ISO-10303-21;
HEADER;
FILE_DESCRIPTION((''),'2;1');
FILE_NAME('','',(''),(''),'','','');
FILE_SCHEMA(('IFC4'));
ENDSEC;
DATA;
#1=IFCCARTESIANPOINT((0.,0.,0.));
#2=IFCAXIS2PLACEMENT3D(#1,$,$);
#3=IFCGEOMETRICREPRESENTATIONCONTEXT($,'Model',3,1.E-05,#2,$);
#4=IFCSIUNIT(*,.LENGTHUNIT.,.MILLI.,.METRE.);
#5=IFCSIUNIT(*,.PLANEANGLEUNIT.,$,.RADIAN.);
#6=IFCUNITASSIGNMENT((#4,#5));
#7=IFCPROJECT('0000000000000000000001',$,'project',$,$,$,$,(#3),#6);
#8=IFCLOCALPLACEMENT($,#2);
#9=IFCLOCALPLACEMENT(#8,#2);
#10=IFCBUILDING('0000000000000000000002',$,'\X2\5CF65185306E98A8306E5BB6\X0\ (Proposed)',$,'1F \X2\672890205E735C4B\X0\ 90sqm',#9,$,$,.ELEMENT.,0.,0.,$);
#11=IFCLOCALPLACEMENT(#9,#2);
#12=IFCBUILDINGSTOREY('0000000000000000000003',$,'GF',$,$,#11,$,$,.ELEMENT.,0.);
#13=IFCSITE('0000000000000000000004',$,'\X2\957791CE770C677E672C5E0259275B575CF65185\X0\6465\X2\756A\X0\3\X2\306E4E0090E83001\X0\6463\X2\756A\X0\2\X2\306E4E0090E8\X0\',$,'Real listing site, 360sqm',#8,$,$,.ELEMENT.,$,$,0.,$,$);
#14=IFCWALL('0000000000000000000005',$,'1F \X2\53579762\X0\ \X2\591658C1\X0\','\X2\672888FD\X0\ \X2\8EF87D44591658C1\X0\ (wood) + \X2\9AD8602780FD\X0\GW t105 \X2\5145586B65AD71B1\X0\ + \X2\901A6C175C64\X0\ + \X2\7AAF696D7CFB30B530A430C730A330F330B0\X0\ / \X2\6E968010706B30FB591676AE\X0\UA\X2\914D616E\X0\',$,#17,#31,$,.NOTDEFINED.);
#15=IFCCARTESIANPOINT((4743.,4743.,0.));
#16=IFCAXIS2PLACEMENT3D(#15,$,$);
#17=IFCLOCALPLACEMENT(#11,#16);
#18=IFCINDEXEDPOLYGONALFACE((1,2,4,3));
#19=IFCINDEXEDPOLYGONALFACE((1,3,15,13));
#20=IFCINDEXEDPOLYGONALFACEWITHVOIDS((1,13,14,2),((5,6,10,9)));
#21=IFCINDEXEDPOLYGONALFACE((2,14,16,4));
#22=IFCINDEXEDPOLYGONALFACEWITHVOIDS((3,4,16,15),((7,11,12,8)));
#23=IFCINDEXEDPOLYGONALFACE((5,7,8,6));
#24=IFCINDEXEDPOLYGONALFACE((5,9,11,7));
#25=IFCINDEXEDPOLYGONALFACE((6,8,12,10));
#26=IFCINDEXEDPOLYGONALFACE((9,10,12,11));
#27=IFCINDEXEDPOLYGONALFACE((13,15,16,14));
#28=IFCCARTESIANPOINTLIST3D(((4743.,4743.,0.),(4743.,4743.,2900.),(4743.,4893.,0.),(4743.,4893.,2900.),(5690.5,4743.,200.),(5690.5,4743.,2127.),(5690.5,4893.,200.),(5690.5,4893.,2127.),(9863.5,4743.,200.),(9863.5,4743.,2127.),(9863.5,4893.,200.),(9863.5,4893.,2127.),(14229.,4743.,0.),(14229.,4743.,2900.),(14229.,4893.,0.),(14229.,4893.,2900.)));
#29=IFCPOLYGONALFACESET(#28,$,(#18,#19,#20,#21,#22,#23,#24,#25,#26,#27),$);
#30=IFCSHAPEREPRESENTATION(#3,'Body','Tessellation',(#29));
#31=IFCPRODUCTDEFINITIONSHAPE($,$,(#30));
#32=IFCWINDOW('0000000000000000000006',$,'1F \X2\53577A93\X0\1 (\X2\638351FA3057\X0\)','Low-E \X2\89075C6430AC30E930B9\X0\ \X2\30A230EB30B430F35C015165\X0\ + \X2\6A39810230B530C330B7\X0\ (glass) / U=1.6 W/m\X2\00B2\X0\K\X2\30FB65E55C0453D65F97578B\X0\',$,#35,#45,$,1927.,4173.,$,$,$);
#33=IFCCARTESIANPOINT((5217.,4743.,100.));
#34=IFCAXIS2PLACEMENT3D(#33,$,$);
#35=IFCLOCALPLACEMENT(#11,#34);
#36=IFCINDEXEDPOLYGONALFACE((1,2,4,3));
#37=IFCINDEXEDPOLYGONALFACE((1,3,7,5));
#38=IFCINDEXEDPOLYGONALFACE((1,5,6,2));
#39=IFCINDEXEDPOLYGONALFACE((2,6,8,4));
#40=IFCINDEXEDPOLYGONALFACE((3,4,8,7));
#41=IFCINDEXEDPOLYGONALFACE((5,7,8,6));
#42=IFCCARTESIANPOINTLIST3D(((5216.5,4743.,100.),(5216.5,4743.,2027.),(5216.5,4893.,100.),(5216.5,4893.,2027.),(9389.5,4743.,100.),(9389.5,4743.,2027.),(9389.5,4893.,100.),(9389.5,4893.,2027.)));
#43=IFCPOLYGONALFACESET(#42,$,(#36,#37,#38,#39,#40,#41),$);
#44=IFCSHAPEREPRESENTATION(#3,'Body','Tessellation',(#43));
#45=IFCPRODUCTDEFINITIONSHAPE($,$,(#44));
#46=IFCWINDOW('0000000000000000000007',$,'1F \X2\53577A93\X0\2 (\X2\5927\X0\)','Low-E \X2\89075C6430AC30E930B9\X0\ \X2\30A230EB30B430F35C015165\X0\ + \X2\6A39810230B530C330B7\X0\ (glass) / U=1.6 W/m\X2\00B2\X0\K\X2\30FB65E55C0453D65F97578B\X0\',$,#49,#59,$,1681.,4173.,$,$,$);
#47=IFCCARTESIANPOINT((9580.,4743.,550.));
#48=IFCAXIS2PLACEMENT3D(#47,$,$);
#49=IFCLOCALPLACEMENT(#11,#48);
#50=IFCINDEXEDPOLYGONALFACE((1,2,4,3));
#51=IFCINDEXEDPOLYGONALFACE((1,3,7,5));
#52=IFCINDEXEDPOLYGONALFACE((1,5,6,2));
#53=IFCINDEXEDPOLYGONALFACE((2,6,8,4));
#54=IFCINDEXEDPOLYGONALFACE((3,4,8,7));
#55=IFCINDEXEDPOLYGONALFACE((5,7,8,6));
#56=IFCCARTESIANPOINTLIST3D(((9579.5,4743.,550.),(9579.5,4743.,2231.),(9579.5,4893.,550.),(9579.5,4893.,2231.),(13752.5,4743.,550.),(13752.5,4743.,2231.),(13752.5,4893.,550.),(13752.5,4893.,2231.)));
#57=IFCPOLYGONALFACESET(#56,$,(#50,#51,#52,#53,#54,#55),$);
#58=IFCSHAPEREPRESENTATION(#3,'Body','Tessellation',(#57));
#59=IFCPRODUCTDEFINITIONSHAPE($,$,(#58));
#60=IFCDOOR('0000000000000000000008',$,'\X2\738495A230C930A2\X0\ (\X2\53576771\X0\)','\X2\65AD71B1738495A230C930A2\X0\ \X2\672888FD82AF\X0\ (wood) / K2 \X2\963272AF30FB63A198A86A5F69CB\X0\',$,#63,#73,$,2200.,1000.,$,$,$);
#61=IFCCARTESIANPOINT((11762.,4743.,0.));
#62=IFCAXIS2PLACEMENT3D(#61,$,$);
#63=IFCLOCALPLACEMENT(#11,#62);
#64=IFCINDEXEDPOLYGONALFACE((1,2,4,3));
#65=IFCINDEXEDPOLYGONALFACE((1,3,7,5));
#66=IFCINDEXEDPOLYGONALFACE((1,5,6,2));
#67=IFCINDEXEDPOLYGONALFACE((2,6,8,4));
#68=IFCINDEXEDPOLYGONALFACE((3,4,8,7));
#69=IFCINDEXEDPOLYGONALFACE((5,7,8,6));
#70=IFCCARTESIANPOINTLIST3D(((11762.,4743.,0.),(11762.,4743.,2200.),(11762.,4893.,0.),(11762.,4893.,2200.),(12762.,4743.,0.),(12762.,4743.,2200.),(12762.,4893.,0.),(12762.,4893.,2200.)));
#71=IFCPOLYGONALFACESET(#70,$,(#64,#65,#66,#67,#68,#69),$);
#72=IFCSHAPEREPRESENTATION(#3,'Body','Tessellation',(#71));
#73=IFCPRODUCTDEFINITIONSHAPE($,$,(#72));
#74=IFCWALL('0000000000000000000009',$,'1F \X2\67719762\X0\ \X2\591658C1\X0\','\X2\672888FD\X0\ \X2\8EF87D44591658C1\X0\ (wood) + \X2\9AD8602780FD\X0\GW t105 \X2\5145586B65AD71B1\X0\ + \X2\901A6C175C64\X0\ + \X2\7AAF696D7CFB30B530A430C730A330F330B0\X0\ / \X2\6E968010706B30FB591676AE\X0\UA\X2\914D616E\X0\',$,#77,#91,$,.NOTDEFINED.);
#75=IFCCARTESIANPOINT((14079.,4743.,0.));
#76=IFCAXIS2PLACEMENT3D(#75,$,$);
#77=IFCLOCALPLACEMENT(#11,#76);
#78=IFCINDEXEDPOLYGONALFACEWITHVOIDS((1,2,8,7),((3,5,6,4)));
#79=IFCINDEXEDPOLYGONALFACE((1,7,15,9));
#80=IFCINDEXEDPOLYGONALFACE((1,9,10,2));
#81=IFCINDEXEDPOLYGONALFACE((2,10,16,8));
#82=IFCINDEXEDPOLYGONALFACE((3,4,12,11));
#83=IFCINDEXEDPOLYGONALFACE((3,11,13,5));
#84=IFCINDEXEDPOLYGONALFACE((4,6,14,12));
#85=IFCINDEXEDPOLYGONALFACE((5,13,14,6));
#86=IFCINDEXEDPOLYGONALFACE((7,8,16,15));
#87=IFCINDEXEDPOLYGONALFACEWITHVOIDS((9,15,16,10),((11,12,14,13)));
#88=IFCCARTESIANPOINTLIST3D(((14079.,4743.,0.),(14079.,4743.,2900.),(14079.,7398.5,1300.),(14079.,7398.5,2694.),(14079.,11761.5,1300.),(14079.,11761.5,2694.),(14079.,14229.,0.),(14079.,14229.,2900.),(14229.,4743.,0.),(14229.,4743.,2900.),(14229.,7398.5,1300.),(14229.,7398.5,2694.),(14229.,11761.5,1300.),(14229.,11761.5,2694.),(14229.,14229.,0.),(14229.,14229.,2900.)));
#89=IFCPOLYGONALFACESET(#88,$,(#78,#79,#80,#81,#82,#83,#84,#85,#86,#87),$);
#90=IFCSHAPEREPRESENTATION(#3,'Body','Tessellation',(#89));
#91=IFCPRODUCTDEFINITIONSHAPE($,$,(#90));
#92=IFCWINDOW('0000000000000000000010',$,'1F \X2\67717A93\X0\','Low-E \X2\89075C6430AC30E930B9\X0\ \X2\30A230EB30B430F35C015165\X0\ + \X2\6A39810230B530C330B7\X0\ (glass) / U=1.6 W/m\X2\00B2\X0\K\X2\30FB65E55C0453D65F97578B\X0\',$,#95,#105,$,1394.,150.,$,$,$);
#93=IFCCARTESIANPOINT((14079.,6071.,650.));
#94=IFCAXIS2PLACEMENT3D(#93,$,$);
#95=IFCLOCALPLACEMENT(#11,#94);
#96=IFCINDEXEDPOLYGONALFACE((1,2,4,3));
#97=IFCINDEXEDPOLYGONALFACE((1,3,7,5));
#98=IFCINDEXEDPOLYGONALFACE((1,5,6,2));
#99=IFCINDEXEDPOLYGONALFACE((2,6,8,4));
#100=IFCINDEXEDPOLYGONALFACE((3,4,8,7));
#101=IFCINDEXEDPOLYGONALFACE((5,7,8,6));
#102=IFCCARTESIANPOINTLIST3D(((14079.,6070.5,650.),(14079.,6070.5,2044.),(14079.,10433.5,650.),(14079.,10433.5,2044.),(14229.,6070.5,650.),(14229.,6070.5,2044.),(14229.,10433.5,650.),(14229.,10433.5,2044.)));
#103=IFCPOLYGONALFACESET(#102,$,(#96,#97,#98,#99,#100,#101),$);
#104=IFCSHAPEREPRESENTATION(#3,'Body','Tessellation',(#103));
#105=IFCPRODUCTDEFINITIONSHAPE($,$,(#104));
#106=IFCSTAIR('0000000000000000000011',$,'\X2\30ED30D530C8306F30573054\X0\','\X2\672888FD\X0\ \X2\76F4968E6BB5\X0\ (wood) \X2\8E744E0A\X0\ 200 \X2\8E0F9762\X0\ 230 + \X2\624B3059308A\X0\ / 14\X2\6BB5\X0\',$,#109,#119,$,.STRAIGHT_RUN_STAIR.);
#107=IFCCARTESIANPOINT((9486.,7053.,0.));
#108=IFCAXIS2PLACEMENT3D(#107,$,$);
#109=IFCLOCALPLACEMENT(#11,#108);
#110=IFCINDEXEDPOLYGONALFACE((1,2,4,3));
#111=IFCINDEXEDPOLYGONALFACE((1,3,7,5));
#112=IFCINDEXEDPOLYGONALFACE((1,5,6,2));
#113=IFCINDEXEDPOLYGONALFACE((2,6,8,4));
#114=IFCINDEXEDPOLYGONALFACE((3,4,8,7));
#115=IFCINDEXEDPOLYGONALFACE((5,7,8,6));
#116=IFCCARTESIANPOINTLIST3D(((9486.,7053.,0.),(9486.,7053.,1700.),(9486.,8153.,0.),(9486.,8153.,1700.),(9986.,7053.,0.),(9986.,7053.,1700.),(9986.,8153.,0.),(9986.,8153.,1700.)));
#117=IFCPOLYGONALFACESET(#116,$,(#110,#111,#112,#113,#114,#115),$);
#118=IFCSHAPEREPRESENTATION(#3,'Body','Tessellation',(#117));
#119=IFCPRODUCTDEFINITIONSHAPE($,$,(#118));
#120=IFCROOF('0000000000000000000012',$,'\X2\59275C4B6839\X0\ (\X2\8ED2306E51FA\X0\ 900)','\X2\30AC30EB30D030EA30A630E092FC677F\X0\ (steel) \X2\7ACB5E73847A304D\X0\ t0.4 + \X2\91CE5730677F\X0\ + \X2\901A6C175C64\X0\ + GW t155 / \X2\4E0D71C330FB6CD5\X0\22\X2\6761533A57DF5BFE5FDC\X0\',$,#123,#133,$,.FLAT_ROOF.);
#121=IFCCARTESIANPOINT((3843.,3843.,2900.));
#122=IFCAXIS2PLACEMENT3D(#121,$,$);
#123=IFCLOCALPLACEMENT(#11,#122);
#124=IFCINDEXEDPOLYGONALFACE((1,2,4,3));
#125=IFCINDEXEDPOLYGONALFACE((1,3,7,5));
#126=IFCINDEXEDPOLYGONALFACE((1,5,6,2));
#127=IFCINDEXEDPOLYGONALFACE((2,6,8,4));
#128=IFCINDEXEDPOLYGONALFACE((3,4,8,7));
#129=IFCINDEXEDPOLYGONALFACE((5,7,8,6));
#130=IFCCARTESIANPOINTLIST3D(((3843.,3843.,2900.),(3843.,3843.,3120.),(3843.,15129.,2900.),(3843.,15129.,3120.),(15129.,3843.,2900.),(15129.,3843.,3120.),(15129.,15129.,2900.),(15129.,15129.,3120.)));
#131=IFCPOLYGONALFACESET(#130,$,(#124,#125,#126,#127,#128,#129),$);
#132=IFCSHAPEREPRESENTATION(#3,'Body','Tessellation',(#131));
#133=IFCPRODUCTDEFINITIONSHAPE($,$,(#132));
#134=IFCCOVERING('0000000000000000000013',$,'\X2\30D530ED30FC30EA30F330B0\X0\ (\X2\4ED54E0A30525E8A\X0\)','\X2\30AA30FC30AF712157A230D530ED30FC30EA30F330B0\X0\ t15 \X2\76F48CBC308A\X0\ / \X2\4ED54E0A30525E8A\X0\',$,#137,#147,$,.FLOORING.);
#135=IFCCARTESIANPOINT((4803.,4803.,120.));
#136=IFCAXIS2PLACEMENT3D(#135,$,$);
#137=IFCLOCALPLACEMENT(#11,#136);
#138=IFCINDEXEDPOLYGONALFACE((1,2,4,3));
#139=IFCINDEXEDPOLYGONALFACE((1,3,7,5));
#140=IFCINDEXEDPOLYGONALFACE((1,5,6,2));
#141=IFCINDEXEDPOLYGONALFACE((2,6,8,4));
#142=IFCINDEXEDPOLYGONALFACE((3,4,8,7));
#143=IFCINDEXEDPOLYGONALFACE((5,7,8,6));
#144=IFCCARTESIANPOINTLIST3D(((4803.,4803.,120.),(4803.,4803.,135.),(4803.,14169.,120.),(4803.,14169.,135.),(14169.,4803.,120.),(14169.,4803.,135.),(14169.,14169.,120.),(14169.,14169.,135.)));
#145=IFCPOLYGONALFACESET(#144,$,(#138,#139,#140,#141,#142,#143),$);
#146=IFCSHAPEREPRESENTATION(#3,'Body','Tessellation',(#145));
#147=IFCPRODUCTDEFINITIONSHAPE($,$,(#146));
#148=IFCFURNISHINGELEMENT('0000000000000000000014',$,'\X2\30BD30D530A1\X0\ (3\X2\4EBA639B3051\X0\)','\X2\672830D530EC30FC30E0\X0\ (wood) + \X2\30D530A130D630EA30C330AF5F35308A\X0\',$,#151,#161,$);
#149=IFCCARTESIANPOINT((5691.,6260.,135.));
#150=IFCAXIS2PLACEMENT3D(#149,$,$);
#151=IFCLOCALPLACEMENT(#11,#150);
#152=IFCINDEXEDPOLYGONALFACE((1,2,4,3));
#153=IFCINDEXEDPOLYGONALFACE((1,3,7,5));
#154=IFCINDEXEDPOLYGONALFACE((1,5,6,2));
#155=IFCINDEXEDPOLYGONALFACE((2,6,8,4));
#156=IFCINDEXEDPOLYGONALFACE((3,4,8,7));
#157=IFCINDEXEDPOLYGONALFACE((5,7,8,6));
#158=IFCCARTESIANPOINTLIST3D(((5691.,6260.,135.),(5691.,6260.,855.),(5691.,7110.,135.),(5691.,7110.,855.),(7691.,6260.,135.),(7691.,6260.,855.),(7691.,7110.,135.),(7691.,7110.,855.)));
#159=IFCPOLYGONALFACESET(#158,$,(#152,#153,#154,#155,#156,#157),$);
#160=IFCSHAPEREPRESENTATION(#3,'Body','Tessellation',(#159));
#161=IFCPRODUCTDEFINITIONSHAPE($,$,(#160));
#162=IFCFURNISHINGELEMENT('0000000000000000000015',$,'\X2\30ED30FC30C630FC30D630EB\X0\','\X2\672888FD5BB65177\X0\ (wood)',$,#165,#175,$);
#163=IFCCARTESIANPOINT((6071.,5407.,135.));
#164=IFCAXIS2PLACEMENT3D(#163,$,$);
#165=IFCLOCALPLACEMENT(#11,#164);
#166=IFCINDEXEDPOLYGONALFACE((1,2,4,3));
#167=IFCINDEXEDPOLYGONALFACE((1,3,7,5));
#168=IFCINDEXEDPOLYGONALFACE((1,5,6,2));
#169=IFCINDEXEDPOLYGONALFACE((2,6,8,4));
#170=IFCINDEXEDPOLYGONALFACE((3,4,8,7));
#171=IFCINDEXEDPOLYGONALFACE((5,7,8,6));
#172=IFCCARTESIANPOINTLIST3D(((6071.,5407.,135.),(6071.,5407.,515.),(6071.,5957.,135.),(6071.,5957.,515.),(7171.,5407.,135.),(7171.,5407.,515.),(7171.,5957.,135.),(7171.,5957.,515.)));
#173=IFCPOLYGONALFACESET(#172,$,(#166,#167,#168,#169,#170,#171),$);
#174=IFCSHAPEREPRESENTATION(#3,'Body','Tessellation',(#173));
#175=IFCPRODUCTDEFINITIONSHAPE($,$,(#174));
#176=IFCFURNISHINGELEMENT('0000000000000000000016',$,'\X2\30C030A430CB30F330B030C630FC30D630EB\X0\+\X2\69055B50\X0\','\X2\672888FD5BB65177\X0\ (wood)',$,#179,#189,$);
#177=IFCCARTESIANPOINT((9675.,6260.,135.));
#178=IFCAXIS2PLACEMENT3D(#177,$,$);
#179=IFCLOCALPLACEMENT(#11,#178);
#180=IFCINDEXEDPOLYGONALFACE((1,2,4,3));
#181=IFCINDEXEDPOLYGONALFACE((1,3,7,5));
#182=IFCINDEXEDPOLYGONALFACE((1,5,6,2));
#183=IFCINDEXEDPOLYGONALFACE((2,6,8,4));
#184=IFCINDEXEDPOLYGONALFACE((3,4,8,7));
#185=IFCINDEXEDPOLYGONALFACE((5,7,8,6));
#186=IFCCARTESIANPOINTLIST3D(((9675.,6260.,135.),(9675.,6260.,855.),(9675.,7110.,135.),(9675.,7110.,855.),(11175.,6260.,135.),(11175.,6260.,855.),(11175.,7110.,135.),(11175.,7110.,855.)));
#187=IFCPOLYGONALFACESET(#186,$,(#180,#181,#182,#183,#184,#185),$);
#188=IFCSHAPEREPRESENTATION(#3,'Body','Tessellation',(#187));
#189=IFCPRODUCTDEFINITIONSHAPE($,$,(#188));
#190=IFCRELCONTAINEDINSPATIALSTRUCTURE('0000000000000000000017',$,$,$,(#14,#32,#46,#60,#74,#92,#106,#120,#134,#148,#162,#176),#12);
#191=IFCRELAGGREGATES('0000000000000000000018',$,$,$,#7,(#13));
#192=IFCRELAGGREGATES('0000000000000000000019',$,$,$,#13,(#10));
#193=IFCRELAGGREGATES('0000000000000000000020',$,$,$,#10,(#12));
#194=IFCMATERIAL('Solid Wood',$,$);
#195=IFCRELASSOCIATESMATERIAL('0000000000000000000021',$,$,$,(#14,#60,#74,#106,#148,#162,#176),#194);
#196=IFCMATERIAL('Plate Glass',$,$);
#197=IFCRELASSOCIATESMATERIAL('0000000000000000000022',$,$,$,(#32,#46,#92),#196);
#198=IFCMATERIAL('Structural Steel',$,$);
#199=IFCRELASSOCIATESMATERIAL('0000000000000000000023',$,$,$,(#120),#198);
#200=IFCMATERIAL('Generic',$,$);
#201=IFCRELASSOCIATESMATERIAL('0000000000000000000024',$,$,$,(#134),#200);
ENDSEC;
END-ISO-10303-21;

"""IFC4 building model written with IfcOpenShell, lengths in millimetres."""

from ifc_helpers import new_model, si_unit, frame, frame_2d, origin, place, context, project, spatial, rectangle, extrude, material, element, fill, save


model = new_model("IFC4")

# Units and contexts
model_context = context("Model", 3, precision=1e-05, world=origin())
ifc_project = project(units=[si_unit("LENGTHUNIT", "METRE", prefix="MILLI"), si_unit("PLANEANGLEUNIT", "RADIAN")], contexts=[model_context])

# Site, building, storey
site_placement = place(None, origin())
site = spatial("IfcSite", under=ifc_project, at=site_placement, Name="長野県松本市大字島内6465番3の一部、6463番2の一部", ObjectType="Real listing site, 360sqm", CompositionType="ELEMENT", RefElevation=0.0)
building_placement = place(site_placement, origin())
building = spatial("IfcBuilding", under=site, at=building_placement, Name="島内の風の家 (Proposed)", ObjectType="1F 木造平屋 90sqm", CompositionType="ELEMENT", ElevationOfRefHeight=0.0, ElevationOfTerrain=0.0)
storey_placement = place(building_placement, origin())
storey = spatial("IfcBuildingStorey", under=building, at=storey_placement, Name="GF", CompositionType="ELEMENT", Elevation=0.0)

# Shared definitions
ifc_material_1 = material(Name="Solid Wood")

# Wall, openings, windows, door
wall_1_placement = place(storey_placement, frame((4743.0, 4743.0, 0.0)))
wall_1 = element("IfcWall", 1, at=wall_1_placement, inside=storey, material=ifc_material_1, Name="1F 南面 外壁", Description="木製 軸組外壁 (wood) + 高性能GW t105 充填断熱 + 通気層 + 窯業系サイディング / 準耐火・外皮UA配慮", PredefinedType="NOTDEFINED", context=model_context, shape_type="SweptSolid", body=[
    extrude(rectangle(XDim=9486.0, YDim=150.0, at=frame_2d((4743.0, 75.0))), frame((4743.0, 4743.0, 0.0)), (0.0, 0.0, 1.0), 2900.0),
])
opening_1_placement = place(storey_placement, frame((5217.0, 4743.0, 100.0)))
opening_1 = element("IfcOpeningElement", 2, at=opening_1_placement, cuts=wall_1, PredefinedType="NOTDEFINED", context=model_context, shape_type="SweptSolid", body=[
    extrude(rectangle(XDim=4173.0, YDim=150.0, at=frame_2d((2086.0, 75.0))), frame((5217.0, 4743.0, 100.0)), (0.0, 0.0, 1.0), 1927.0),
])
opening_2_placement = place(storey_placement, frame((9580.0, 4743.0, 550.0)))
opening_2 = element("IfcOpeningElement", 3, at=opening_2_placement, cuts=wall_1, PredefinedType="NOTDEFINED", context=model_context, shape_type="SweptSolid", body=[
    extrude(rectangle(XDim=4173.0, YDim=150.0, at=frame_2d((2086.0, 75.0))), frame((9580.0, 4743.0, 550.0)), (0.0, 0.0, 1.0), 1681.0),
])
opening_3_placement = place(storey_placement, frame((11762.0, 4743.0, 0.0)))
opening_3 = element("IfcOpeningElement", 4, at=opening_3_placement, cuts=wall_1, PredefinedType="NOTDEFINED", context=model_context, shape_type="SweptSolid", body=[
    extrude(rectangle(XDim=1000.0, YDim=150.0, at=frame_2d((500.0, 75.0))), frame((11762.0, 4743.0, 0.0)), (0.0, 0.0, 1.0), 2200.0),
])
ifc_material_2 = material(Name="Plate Glass")
window_1_placement = place(storey_placement, frame((5217.0, 4743.0, 100.0)))
window_1 = element("IfcWindow", 5, at=window_1_placement, inside=storey, material=ifc_material_2, Name="1F 南窓1 (掃出し)", Description="Low-E 複層ガラス アルゴン封入 + 樹脂サッシ (glass) / U=1.6 W/m²K・日射取得型", OverallHeight=1927.0, OverallWidth=4173.0, context=model_context, shape_type="SweptSolid", body=[
    extrude(rectangle(XDim=4173.0, YDim=150.0, at=frame_2d((2086.0, 75.0))), frame((5217.0, 4743.0, 100.0)), (0.0, 0.0, 1.0), 1927.0),
])
fill(opening_1, window_1)
window_2_placement = place(storey_placement, frame((9580.0, 4743.0, 550.0)))
window_2 = element("IfcWindow", 6, at=window_2_placement, inside=storey, material=ifc_material_2, Name="1F 南窓2 (大)", Description="Low-E 複層ガラス アルゴン封入 + 樹脂サッシ (glass) / U=1.6 W/m²K・日射取得型", OverallHeight=1681.0, OverallWidth=4173.0, context=model_context, shape_type="SweptSolid", body=[
    extrude(rectangle(XDim=4173.0, YDim=150.0, at=frame_2d((2086.0, 75.0))), frame((9580.0, 4743.0, 550.0)), (0.0, 0.0, 1.0), 1681.0),
])
fill(opening_2, window_2)
door_placement = place(storey_placement, frame((11762.0, 4743.0, 0.0)))
door = element("IfcDoor", 7, at=door_placement, inside=storey, material=ifc_material_1, Name="玄関ドア (南東)", Description="断熱玄関ドア 木製芯 (wood) / K2 防犯・採風機構", OverallHeight=2200.0, OverallWidth=1000.0, context=model_context, shape_type="SweptSolid", body=[
    extrude(rectangle(XDim=1000.0, YDim=150.0, at=frame_2d((500.0, 75.0))), frame((11762.0, 4743.0, 0.0)), (0.0, 0.0, 1.0), 2200.0),
])
fill(opening_3, door)

# Wall, opening, window
wall_2_placement = place(storey_placement, frame((14079.0, 4743.0, 0.0)))
wall_2 = element("IfcWall", 8, at=wall_2_placement, inside=storey, material=ifc_material_1, Name="1F 東面 外壁", Description="木製 軸組外壁 (wood) + 高性能GW t105 充填断熱 + 通気層 + 窯業系サイディング / 準耐火・外皮UA配慮", PredefinedType="NOTDEFINED", context=model_context, shape_type="SweptSolid", body=[
    extrude(rectangle(XDim=150.0, YDim=9486.0, at=frame_2d((75.0, 4743.0))), frame((14079.0, 4743.0, 0.0)), (0.0, 0.0, 1.0), 2900.0),
])
opening_4_placement = place(storey_placement, frame((14079.0, 6071.0, 650.0)))
opening_4 = element("IfcOpeningElement", 9, at=opening_4_placement, cuts=wall_2, PredefinedType="NOTDEFINED", context=model_context, shape_type="SweptSolid", body=[
    extrude(rectangle(XDim=150.0, YDim=4363.0, at=frame_2d((75.0, 2181.0))), frame((14079.0, 6071.0, 650.0)), (0.0, 0.0, 1.0), 1394.0),
])
window_3_placement = place(storey_placement, frame((14079.0, 6071.0, 650.0)))
window_3 = element("IfcWindow", 10, at=window_3_placement, inside=storey, material=ifc_material_2, Name="1F 東窓", Description="Low-E 複層ガラス アルゴン封入 + 樹脂サッシ (glass) / U=1.6 W/m²K・日射取得型", OverallHeight=1394.0, OverallWidth=150.0, context=model_context, shape_type="SweptSolid", body=[
    extrude(rectangle(XDim=150.0, YDim=4363.0, at=frame_2d((75.0, 2181.0))), frame((14079.0, 6071.0, 650.0)), (0.0, 0.0, 1.0), 1394.0),
])
fill(opening_4, window_3)

# Stair
stair_placement = place(storey_placement, frame((9486.0, 7053.0, 0.0)))
element("IfcStair", 11, at=stair_placement, inside=storey, material=ifc_material_1, Name="ロフトはしご", Description="木製 直階段 (wood) 蹴上 200 踏面 230 + 手すり / 14段", PredefinedType="STRAIGHT_RUN_STAIR", context=model_context, shape_type="SweptSolid", body=[
    extrude(rectangle(XDim=500.0, YDim=1100.0, at=frame_2d((250.0, 550.0))), frame((9486.0, 7053.0, 0.0)), (0.0, 0.0, 1.0), 1700.0),
])

# Roof
ifc_material_3 = material(Name="Structural Steel")
roof_placement = place(storey_placement, frame((3843.0, 3843.0, 2900.0)))
element("IfcRoof", 12, at=roof_placement, inside=storey, material=ifc_material_3, Name="大屋根 (軒の出 900)", Description="ガルバリウム鋼板 (steel) 立平葺き t0.4 + 野地板 + 通気層 + GW t155 / 不燃・法22条区域対応", PredefinedType="FLAT_ROOF", context=model_context, shape_type="SweptSolid", body=[
    extrude(rectangle(XDim=11286.0, YDim=11286.0, at=frame_2d((5643.0, 5643.0))), frame((3843.0, 3843.0, 2900.0)), (0.0, 0.0, 1.0), 220.0),
])

# Covering
ifc_material_4 = material(Name="Generic")
covering_placement = place(storey_placement, frame((4803.0, 4803.0, 120.0)))
element("IfcCovering", 13, at=covering_placement, inside=storey, material=ifc_material_4, Name="フローリング (仕上げ床)", Description="オーク無垢フローリング t15 直貼り / 仕上げ床", PredefinedType="FLOORING", context=model_context, shape_type="SweptSolid", body=[
    extrude(rectangle(XDim=9366.0, YDim=9366.0, at=frame_2d((4683.0, 4683.0))), frame((4803.0, 4803.0, 120.0)), (0.0, 0.0, 1.0), 15.0),
])

# Furnishing elements
furnishing_1_placement = place(storey_placement, frame((5691.0, 6260.0, 135.0)))
element("IfcFurnishingElement", 14, at=furnishing_1_placement, inside=storey, material=ifc_material_1, Name="ソファ (3人掛け)", Description="木フレーム (wood) + ファブリック張り", context=model_context, shape_type="SweptSolid", body=[
    extrude(rectangle(XDim=2000.0, YDim=850.0, at=frame_2d((1000.0, 425.0))), frame((5691.0, 6260.0, 135.0)), (0.0, 0.0, 1.0), 720.0),
])
furnishing_2_placement = place(storey_placement, frame((6071.0, 5407.0, 135.0)))
element("IfcFurnishingElement", 15, at=furnishing_2_placement, inside=storey, material=ifc_material_1, Name="ローテーブル", Description="木製家具 (wood)", context=model_context, shape_type="SweptSolid", body=[
    extrude(rectangle(XDim=1100.0, YDim=550.0, at=frame_2d((550.0, 275.0))), frame((6071.0, 5407.0, 135.0)), (0.0, 0.0, 1.0), 380.0),
])
furnishing_3_placement = place(storey_placement, frame((9675.0, 6260.0, 135.0)))
element("IfcFurnishingElement", 16, at=furnishing_3_placement, inside=storey, material=ifc_material_1, Name="ダイニングテーブル+椅子", Description="木製家具 (wood)", context=model_context, shape_type="SweptSolid", body=[
    extrude(rectangle(XDim=1500.0, YDim=850.0, at=frame_2d((750.0, 425.0))), frame((9675.0, 6260.0, 135.0)), (0.0, 0.0, 1.0), 720.0),
])

save(model, "model.ifc")
